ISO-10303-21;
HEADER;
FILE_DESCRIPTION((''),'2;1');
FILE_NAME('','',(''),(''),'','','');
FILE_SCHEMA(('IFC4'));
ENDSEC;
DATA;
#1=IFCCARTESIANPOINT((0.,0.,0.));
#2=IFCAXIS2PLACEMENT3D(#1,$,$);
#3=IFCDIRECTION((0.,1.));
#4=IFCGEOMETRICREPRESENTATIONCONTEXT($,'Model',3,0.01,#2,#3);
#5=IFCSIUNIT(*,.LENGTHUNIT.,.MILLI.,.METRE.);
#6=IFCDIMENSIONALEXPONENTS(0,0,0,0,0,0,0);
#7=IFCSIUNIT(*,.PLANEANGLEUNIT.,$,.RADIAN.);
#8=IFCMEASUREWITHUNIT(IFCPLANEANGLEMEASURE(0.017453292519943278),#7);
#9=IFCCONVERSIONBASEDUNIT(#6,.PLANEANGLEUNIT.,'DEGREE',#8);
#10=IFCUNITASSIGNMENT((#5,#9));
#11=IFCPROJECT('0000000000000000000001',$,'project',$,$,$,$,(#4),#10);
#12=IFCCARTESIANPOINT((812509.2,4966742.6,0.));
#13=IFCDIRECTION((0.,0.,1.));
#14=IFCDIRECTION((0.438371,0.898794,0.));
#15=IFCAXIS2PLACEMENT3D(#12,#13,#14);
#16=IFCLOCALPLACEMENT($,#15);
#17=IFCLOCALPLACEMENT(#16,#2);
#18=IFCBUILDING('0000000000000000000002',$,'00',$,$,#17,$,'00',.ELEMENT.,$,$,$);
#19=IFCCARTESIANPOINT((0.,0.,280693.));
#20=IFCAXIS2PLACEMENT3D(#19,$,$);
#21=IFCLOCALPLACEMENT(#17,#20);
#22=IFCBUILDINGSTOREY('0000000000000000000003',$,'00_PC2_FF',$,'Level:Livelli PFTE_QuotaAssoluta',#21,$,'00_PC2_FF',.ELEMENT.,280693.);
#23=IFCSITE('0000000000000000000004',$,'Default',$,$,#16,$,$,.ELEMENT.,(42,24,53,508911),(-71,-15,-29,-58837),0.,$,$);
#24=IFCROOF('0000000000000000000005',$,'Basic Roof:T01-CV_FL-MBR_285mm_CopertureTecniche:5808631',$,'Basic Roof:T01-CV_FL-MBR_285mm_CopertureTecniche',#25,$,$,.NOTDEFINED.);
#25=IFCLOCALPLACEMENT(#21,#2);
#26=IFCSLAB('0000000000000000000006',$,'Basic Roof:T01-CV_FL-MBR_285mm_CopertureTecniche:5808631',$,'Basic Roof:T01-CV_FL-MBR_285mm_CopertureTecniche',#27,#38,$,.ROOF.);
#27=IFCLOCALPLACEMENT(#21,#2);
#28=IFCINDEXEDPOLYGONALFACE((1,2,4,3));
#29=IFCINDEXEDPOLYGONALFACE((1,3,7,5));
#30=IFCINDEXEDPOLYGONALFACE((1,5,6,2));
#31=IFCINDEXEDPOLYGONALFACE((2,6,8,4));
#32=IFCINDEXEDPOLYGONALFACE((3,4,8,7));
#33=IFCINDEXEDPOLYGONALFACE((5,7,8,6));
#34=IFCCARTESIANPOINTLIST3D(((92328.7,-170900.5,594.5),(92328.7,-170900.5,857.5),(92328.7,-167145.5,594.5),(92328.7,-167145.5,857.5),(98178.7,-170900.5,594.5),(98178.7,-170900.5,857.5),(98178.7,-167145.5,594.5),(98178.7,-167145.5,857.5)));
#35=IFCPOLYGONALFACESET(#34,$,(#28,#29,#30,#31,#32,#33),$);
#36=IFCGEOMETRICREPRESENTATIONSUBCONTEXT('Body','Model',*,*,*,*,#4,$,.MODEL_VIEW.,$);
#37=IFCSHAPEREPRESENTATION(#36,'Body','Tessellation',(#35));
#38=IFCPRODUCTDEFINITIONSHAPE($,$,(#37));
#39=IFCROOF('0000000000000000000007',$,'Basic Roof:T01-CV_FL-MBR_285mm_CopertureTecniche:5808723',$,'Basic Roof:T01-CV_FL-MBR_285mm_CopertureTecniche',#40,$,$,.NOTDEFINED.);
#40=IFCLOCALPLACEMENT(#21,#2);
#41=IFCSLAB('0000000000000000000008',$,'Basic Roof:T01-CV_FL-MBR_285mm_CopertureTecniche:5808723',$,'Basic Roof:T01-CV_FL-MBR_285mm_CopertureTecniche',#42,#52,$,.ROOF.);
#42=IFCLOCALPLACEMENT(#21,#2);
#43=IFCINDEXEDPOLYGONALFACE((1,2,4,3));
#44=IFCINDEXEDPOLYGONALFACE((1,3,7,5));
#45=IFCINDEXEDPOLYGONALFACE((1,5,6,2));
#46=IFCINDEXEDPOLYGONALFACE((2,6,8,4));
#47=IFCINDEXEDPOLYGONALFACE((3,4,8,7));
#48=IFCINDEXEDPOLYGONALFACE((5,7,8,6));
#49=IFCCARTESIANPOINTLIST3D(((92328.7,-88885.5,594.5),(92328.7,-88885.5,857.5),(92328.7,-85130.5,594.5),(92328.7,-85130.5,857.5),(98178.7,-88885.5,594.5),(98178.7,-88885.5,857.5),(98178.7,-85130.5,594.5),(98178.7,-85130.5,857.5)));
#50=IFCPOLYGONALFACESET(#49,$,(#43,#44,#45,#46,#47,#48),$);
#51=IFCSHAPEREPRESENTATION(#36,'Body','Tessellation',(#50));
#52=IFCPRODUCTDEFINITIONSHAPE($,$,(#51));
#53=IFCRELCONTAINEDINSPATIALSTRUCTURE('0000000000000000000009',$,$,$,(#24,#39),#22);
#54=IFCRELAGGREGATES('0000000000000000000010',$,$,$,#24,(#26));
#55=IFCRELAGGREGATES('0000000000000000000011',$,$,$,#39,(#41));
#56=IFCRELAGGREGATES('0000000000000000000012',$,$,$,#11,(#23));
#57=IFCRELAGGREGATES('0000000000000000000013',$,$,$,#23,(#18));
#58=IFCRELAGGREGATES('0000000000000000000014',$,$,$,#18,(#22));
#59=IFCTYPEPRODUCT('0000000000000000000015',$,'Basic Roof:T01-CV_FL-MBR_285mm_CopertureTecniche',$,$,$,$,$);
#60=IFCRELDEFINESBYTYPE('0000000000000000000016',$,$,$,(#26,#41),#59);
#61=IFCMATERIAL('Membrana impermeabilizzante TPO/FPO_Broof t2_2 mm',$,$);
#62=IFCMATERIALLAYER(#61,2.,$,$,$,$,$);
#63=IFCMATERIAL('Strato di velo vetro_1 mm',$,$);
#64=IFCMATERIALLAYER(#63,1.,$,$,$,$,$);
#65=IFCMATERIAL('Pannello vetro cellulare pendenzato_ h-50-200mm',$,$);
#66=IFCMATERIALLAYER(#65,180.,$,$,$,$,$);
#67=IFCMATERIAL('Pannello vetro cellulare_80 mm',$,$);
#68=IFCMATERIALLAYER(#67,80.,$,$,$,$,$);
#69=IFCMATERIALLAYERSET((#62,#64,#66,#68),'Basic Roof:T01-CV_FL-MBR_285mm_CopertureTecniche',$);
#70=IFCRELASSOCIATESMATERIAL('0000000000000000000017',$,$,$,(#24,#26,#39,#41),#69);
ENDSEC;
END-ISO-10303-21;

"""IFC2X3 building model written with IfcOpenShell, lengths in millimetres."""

from ifc_helpers import new_model, entity, si_unit, converted_unit, direction, frame, origin, origin_2d_with_axis, place, context, subcontext, project, spatial, rectangle, extrude, material, layer, layer_set, type_object, element, aggregate, save


model = new_model("IFC2X3")

# Units and contexts
model_context = context("Model", 3, precision=0.01, world=origin(), true_north=direction((0.0, 1.0)))
body_context = subcontext(model_context, "Body", "Model", "MODEL_VIEW")
ifc_project = project(units=[si_unit("LENGTHUNIT", "METRE", prefix="MILLI"), converted_unit("PLANEANGLEUNIT", "DEGREE", entity("IfcPlaneAngleMeasure", 0.017453292519943278), si_unit("PLANEANGLEUNIT", "RADIAN"), dimensions=[0, 0, 0, 0, 0, 0, 0])], contexts=[model_context])

# Site, building, storey
site_placement = place(None, frame((812509.2, 4966742.6, 0.0), z_axis=(0.0, 0.0, 1.0), x_axis=(0.438371, 0.898794, 0.0)))
site = spatial("IfcSite", under=ifc_project, at=site_placement, Name="Default", CompositionType="ELEMENT", RefLatitude=(42, 24, 53, 508911), RefLongitude=(-71, -15, -29, -58837), RefElevation=0.0)
building_placement = place(site_placement, origin())
building = spatial("IfcBuilding", under=site, at=building_placement, Name="00", LongName="00", CompositionType="ELEMENT")
storey_placement = place(building_placement, frame((0.0, 0.0, 280693.0)))
storey = spatial("IfcBuildingStorey", under=building, at=storey_placement, Name="00_PC2_FF", ObjectType="Level:Livelli PFTE_QuotaAssoluta", LongName="00_PC2_FF", CompositionType="ELEMENT", Elevation=280693.0)

# Roofs, slabs
ifc_material_1 = material(Name="Membrana impermeabilizzante TPO/FPO_Broof t2_2 mm")
ifc_layer_1 = layer(ifc_material_1, 2.0)
ifc_material_2 = material(Name="Strato di velo vetro_1 mm")
ifc_layer_2 = layer(ifc_material_2, 1.0)
ifc_material_3 = material(Name="Pannello vetro cellulare pendenzato_ h-50-200mm")
ifc_layer_3 = layer(ifc_material_3, 180.0)
ifc_material_4 = material(Name="Pannello vetro cellulare_80 mm")
ifc_layer_4 = layer(ifc_material_4, 80.0)
ifc_layer_set = layer_set([ifc_layer_1, ifc_layer_2, ifc_layer_3, ifc_layer_4], Name="Basic Roof:T01-CV_FL-MBR_285mm_CopertureTecniche")
roof_1_placement = place(storey_placement, frame((92328.7, -170900.5, 594.5)))
roof_1 = element("IfcRoof", 1, at=roof_1_placement, inside=storey, material=ifc_layer_set, Name="Basic Roof:T01-CV_FL-MBR_285mm_CopertureTecniche:5808631", ObjectType="Basic Roof:T01-CV_FL-MBR_285mm_CopertureTecniche", ShapeType="NOTDEFINED")
type_product = type_object("IfcTypeProduct", Name="Basic Roof:T01-CV_FL-MBR_285mm_CopertureTecniche")
slab_1_placement = place(roof_1_placement, origin())
slab_1 = element("IfcSlab", 2, at=slab_1_placement, type_object=type_product, material=ifc_layer_set, Name="Basic Roof:T01-CV_FL-MBR_285mm_CopertureTecniche:5808631", ObjectType="Basic Roof:T01-CV_FL-MBR_285mm_CopertureTecniche", PredefinedType="ROOF", context=body_context, shape_type="SweptSolid", body=[
    extrude(rectangle(XDim=5850.0, YDim=3755.0, at=origin_2d_with_axis()), frame((2925.0, 1877.5, 0.0)), (0.0, 0.0, 1.0), 263.0),
])
aggregate(roof_1, [slab_1])
roof_2_placement = place(storey_placement, frame((92328.7, -88885.5, 594.5)))
roof_2 = element("IfcRoof", 3, at=roof_2_placement, inside=storey, material=ifc_layer_set, Name="Basic Roof:T01-CV_FL-MBR_285mm_CopertureTecniche:5808723", ObjectType="Basic Roof:T01-CV_FL-MBR_285mm_CopertureTecniche", ShapeType="NOTDEFINED")
slab_2_placement = place(roof_2_placement, origin())
slab_2 = element("IfcSlab", 4, at=slab_2_placement, type_object=type_product, material=ifc_layer_set, Name="Basic Roof:T01-CV_FL-MBR_285mm_CopertureTecniche:5808723", ObjectType="Basic Roof:T01-CV_FL-MBR_285mm_CopertureTecniche", PredefinedType="ROOF", context=body_context, shape_type="SweptSolid", body=[
    extrude(rectangle(XDim=5850.0, YDim=3755.0, at=origin_2d_with_axis()), frame((2925.0, 1877.5, 0.0)), (0.0, 0.0, 1.0), 263.0),
])
aggregate(roof_2, [slab_2])

save(model, "model.ifc")
